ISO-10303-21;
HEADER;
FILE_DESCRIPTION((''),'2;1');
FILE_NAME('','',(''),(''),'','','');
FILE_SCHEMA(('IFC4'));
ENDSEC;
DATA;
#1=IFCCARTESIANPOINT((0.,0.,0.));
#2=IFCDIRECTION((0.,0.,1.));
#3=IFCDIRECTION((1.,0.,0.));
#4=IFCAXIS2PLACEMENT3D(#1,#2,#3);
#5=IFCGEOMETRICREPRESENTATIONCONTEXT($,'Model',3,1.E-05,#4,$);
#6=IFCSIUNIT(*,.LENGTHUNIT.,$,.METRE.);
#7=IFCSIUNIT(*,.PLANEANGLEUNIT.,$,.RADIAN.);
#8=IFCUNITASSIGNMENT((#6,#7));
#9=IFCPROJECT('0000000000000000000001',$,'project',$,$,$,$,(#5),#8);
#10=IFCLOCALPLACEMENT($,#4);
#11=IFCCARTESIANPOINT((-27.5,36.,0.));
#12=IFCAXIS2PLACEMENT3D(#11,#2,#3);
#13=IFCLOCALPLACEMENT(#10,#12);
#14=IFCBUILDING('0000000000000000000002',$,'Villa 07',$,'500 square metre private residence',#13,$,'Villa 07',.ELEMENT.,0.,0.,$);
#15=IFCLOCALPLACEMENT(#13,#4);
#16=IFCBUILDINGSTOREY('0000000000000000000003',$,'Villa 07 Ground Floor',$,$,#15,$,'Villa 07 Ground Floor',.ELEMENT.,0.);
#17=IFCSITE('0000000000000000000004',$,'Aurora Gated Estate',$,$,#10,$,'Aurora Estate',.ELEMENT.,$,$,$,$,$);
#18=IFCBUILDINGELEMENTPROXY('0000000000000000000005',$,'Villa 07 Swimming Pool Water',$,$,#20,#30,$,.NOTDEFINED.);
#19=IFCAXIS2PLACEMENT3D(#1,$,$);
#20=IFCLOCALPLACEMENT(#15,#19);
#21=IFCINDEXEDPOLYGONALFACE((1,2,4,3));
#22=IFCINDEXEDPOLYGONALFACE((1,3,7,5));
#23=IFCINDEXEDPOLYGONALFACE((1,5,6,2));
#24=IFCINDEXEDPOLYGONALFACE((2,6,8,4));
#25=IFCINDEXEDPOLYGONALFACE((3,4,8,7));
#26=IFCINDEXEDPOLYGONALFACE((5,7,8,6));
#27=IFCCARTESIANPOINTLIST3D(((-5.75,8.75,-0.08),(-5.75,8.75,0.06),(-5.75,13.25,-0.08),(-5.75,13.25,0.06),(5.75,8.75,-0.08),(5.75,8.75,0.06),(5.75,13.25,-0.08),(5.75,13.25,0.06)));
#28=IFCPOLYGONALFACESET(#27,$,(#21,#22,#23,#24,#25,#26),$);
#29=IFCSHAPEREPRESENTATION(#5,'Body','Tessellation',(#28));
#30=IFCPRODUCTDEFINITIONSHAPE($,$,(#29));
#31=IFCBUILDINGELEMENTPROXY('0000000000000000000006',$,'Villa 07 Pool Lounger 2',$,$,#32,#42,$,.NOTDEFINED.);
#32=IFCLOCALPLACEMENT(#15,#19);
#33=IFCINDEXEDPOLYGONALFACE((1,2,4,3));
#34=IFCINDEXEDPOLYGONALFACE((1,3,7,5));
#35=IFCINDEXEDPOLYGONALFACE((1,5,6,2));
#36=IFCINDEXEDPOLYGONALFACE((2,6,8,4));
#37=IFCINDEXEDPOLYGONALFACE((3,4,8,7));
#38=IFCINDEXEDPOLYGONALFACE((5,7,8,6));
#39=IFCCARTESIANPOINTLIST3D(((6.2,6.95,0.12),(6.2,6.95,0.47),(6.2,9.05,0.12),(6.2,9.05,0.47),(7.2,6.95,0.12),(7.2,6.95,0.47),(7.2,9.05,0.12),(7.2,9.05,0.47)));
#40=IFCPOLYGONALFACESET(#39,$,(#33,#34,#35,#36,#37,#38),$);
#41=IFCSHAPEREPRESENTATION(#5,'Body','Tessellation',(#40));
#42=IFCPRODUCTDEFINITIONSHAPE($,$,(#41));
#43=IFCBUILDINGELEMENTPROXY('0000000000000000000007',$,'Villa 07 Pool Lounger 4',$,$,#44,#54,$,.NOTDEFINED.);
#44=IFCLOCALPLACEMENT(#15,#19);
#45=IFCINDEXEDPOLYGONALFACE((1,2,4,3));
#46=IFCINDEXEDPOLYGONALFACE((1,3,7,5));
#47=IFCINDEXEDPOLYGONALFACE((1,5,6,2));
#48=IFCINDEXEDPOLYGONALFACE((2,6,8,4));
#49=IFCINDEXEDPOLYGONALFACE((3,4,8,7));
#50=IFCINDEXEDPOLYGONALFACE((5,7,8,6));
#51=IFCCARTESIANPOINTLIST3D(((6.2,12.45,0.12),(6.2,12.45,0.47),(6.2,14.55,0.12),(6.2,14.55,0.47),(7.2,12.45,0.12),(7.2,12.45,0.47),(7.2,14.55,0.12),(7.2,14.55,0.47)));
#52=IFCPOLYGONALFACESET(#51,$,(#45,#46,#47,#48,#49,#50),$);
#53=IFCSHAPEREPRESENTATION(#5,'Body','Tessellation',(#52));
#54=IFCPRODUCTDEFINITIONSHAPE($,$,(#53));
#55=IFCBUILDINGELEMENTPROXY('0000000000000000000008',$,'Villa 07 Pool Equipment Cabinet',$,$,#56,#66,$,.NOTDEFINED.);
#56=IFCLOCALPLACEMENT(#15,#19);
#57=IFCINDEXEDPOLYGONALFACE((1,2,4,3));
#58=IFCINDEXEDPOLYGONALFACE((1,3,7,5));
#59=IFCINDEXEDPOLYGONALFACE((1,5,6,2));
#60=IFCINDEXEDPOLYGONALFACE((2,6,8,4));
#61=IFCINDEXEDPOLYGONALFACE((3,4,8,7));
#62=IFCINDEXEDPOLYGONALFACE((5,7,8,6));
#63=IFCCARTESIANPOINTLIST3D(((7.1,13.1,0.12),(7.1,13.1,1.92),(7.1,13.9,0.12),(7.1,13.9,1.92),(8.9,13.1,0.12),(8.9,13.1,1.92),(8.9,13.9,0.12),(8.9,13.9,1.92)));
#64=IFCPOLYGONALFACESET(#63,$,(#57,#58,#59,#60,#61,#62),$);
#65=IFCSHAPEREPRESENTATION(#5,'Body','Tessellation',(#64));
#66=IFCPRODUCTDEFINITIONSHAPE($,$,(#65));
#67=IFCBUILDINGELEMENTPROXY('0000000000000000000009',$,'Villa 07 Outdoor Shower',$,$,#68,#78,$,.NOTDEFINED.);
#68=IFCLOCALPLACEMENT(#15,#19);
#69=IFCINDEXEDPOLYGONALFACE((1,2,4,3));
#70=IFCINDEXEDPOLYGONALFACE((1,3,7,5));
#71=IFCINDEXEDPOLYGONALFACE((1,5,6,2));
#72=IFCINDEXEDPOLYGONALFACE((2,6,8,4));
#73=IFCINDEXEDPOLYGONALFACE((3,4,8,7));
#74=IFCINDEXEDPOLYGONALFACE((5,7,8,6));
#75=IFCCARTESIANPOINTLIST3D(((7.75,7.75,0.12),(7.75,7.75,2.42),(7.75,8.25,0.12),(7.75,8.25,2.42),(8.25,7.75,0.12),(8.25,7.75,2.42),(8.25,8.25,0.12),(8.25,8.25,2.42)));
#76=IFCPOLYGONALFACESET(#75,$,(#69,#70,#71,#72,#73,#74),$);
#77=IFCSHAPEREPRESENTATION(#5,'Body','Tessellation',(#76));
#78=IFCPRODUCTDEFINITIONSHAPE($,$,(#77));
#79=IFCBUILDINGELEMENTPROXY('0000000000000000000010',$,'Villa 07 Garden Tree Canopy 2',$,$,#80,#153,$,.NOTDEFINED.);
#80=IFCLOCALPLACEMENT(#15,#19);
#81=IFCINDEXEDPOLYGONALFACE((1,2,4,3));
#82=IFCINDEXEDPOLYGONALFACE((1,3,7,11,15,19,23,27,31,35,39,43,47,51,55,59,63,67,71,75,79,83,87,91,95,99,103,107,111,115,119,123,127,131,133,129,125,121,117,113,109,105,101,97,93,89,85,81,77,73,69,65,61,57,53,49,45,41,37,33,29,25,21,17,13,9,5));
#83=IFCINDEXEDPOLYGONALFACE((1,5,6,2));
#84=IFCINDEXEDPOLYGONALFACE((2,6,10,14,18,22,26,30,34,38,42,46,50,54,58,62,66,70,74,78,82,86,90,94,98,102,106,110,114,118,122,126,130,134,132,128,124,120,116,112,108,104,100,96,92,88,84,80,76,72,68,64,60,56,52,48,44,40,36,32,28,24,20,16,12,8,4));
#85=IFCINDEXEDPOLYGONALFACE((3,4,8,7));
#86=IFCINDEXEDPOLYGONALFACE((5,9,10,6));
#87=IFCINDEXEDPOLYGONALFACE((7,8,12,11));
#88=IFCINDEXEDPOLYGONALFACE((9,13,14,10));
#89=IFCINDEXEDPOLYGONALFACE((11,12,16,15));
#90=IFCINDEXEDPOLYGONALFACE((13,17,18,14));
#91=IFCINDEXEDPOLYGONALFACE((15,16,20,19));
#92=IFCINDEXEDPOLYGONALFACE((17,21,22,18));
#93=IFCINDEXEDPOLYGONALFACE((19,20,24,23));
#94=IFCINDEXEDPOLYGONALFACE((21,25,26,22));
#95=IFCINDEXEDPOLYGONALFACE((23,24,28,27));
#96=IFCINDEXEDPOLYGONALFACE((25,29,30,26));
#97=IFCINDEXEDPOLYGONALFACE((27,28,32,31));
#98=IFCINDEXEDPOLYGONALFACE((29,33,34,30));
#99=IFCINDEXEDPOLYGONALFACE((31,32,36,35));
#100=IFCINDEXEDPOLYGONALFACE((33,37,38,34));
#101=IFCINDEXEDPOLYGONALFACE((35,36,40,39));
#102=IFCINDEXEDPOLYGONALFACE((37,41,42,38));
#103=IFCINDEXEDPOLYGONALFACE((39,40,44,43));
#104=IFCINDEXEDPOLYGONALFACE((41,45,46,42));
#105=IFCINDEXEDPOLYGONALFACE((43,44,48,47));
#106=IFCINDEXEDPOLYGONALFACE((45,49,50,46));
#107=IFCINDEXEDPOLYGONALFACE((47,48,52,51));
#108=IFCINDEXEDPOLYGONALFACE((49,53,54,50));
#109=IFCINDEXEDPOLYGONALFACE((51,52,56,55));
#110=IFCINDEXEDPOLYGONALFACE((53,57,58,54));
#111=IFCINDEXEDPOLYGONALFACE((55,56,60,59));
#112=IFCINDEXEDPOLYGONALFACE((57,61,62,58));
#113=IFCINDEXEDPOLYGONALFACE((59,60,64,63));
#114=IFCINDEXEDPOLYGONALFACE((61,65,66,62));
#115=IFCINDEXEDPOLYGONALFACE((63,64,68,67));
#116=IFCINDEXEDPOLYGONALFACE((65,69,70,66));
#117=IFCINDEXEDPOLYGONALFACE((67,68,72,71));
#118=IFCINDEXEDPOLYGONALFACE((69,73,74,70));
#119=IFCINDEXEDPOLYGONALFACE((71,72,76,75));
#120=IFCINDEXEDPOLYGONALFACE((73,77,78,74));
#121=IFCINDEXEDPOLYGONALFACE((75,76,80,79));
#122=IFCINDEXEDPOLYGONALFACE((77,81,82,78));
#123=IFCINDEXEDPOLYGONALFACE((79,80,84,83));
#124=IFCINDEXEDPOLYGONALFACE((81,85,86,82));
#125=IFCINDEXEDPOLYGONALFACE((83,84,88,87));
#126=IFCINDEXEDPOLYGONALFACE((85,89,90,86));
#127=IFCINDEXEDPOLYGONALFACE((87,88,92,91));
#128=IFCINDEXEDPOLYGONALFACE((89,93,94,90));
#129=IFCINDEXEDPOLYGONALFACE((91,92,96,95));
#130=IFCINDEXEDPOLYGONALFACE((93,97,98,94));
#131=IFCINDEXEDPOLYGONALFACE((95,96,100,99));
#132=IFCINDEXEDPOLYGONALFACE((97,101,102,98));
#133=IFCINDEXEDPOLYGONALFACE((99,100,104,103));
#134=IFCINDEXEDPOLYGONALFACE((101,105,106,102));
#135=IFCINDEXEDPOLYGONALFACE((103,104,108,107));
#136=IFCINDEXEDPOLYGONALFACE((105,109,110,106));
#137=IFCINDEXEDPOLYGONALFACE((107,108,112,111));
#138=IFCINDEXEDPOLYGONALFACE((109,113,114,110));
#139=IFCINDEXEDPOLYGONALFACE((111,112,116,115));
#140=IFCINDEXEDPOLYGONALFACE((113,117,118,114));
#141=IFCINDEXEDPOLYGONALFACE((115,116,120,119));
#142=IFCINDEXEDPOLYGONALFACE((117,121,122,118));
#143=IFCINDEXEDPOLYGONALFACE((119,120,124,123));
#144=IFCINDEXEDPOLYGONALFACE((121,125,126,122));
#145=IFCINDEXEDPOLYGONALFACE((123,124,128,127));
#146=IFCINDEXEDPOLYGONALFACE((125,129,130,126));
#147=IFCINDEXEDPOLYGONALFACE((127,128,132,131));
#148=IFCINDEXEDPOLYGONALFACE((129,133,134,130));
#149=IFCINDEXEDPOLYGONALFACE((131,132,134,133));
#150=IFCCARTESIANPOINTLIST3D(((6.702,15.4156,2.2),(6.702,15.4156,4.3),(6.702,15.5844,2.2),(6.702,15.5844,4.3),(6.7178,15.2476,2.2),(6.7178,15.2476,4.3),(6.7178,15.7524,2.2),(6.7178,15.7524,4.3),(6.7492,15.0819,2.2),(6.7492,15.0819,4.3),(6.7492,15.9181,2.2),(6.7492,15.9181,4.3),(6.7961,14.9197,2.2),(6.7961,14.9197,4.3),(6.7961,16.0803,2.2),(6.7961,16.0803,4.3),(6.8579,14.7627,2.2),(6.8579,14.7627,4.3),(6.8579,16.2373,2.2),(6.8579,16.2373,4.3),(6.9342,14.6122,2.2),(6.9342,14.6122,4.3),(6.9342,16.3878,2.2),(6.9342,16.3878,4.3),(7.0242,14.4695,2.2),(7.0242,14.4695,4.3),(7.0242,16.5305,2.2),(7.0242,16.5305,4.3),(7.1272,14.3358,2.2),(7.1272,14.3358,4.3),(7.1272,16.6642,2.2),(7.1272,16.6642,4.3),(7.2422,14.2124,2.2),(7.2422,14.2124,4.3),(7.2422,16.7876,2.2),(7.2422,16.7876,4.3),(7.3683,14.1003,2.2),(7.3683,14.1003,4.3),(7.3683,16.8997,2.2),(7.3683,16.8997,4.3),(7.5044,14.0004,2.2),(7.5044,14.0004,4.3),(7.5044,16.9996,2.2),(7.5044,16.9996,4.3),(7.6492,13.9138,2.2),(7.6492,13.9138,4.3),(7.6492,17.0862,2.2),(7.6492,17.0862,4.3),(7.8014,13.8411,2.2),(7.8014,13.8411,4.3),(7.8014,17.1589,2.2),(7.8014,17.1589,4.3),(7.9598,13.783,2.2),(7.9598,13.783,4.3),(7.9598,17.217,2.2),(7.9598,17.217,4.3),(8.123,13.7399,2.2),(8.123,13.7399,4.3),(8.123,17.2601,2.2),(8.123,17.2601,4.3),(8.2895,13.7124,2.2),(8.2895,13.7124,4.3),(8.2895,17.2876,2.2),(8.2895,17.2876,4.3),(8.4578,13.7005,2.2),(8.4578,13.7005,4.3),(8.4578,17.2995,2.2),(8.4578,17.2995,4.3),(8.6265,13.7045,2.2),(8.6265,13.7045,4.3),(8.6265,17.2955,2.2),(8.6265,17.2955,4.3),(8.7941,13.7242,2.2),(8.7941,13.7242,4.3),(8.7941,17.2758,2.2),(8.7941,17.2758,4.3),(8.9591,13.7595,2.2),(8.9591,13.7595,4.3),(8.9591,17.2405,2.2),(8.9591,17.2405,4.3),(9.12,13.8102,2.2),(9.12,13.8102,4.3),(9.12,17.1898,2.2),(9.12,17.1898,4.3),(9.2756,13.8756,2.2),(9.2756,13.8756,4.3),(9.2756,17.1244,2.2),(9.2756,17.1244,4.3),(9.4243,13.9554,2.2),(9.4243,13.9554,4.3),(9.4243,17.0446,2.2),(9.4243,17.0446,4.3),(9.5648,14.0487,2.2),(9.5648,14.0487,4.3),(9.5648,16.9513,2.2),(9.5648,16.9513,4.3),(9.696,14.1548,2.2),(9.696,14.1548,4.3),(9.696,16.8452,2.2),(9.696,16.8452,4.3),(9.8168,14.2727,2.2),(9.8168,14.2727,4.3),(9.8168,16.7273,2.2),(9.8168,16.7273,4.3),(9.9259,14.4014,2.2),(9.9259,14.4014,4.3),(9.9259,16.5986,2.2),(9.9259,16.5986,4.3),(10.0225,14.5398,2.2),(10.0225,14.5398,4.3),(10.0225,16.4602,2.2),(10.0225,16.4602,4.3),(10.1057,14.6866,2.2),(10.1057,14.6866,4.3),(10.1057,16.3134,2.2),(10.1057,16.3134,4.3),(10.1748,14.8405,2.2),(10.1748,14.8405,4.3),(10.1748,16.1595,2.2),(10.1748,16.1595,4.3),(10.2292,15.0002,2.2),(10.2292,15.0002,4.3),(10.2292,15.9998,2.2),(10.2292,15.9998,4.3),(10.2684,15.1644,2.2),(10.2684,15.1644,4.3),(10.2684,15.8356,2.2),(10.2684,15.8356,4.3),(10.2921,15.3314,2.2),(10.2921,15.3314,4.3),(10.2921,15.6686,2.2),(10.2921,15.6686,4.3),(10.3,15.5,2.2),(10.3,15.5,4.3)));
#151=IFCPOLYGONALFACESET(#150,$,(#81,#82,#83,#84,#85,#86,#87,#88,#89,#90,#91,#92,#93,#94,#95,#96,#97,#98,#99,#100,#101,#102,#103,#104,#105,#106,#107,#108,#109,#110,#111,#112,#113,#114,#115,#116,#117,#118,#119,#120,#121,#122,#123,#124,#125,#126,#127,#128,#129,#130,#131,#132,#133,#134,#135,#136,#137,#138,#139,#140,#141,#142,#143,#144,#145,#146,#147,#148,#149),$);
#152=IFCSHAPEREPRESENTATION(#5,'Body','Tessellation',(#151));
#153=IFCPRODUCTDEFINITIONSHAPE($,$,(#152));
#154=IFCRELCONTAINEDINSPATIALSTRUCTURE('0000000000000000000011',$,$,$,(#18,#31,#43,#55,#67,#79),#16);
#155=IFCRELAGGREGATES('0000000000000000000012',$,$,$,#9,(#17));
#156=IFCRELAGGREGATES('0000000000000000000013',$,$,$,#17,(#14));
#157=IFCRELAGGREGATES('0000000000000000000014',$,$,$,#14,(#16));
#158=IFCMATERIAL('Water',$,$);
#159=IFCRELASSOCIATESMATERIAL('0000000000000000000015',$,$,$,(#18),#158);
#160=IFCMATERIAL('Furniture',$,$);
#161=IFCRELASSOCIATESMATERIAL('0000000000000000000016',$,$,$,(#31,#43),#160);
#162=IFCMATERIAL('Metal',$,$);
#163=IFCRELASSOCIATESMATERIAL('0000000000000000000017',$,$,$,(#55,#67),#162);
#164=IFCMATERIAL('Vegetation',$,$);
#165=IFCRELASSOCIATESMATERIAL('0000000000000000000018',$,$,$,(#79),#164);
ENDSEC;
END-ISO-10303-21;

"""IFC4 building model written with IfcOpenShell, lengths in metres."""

from ifc_helpers import new_model, si_unit, frame, origin_with_axes, origin_2d_with_axis, place, context, project, spatial, rectangle, circle, extrude, material, element, save


model = new_model("IFC4")

# Units and contexts
model_context = context("Model", 3, precision=1e-05, world=origin_with_axes())
ifc_project = project(units=[si_unit("LENGTHUNIT", "METRE"), si_unit("PLANEANGLEUNIT", "RADIAN")], contexts=[model_context])

# Site, building, storey
site_placement = place(None, origin_with_axes())
site = spatial("IfcSite", under=ifc_project, at=site_placement, Name="Aurora Gated Estate", LongName="Aurora Estate", CompositionType="ELEMENT")
building_placement = place(site_placement, frame((-27.5, 36.0, 0.0), z_axis=(0.0, 0.0, 1.0), x_axis=(1.0, 0.0, 0.0)))
building = spatial("IfcBuilding", under=site, at=building_placement, Name="Villa 07", ObjectType="500 square metre private residence", LongName="Villa 07", CompositionType="ELEMENT", ElevationOfRefHeight=0.0, ElevationOfTerrain=0.0)
storey_placement = place(building_placement, origin_with_axes())
storey = spatial("IfcBuildingStorey", under=building, at=storey_placement, Name="Villa 07 Ground Floor", LongName="Villa 07 Ground Floor", CompositionType="ELEMENT", Elevation=0.0)

# Building element proxies
ifc_material_1 = material(Name="Furniture")
ifc_material_2 = material(Name="Metal")
ifc_material_3 = material(Name="Water")
proxy_1_placement = place(storey_placement, frame((0.0, 11.0, -0.08), z_axis=(0.0, 0.0, 1.0), x_axis=(1.0, 0.0, 0.0)))
element("IfcBuildingElementProxy", 1, at=proxy_1_placement, inside=storey, material=ifc_material_3, Name="Villa 07 Swimming Pool Water", PredefinedType="NOTDEFINED", context=model_context, shape_type="SweptSolid", body=[
    extrude(rectangle(XDim=11.5, YDim=4.5, at=origin_2d_with_axis()), origin_with_axes(), (0.0, 0.0, 1.0), 0.14),
])
for number, where, z_axis, x_axis, name in (
    (2, (6.7, 8.0, 0.12), (0.0, 0.0, 1.0), (1.0, 0.0, 0.0), "Villa 07 Pool Lounger 2"),
    (3, (6.7, 13.5, 0.12), (0.0, 0.0, 1.0), (1.0, 0.0, 0.0), "Villa 07 Pool Lounger 4"),
):
    element("IfcBuildingElementProxy", number, at=place(storey_placement, frame(where, z_axis=z_axis, x_axis=x_axis)), inside=storey, material=ifc_material_1, Name=name, PredefinedType="NOTDEFINED", context=model_context, shape_type="SweptSolid", body=[
        extrude(rectangle(XDim=1.0, YDim=2.1, at=origin_2d_with_axis()), origin_with_axes(), (0.0, 0.0, 1.0), 0.35),
    ])
proxy_2_placement = place(storey_placement, frame((8.0, 13.5, 0.12), z_axis=(0.0, 0.0, 1.0), x_axis=(1.0, 0.0, 0.0)))
element("IfcBuildingElementProxy", 4, at=proxy_2_placement, inside=storey, material=ifc_material_2, Name="Villa 07 Pool Equipment Cabinet", PredefinedType="NOTDEFINED", context=model_context, shape_type="SweptSolid", body=[
    extrude(rectangle(XDim=1.8, YDim=0.8, at=origin_2d_with_axis()), origin_with_axes(), (0.0, 0.0, 1.0), 1.8),
])
proxy_3_placement = place(storey_placement, frame((8.0, 8.0, 0.12), z_axis=(0.0, 0.0, 1.0), x_axis=(1.0, 0.0, 0.0)))
element("IfcBuildingElementProxy", 5, at=proxy_3_placement, inside=storey, material=ifc_material_2, Name="Villa 07 Outdoor Shower", PredefinedType="NOTDEFINED", context=model_context, shape_type="SweptSolid", body=[
    extrude(rectangle(XDim=0.5, YDim=0.5, at=origin_2d_with_axis()), origin_with_axes(), (0.0, 0.0, 1.0), 2.3),
])
ifc_material_4 = material(Name="Vegetation")
proxy_4_placement = place(storey_placement, frame((8.5, 15.5, 2.2), z_axis=(0.0, 0.0, 1.0), x_axis=(1.0, 0.0, 0.0)))
element("IfcBuildingElementProxy", 6, at=proxy_4_placement, inside=storey, material=ifc_material_4, Name="Villa 07 Garden Tree Canopy 2", PredefinedType="NOTDEFINED", context=model_context, shape_type="SweptSolid", body=[
    extrude(circle(Radius=1.8, at=origin_2d_with_axis()), origin_with_axes(), (0.0, 0.0, 1.0), 2.1),
])

save(model, "model.ifc")
